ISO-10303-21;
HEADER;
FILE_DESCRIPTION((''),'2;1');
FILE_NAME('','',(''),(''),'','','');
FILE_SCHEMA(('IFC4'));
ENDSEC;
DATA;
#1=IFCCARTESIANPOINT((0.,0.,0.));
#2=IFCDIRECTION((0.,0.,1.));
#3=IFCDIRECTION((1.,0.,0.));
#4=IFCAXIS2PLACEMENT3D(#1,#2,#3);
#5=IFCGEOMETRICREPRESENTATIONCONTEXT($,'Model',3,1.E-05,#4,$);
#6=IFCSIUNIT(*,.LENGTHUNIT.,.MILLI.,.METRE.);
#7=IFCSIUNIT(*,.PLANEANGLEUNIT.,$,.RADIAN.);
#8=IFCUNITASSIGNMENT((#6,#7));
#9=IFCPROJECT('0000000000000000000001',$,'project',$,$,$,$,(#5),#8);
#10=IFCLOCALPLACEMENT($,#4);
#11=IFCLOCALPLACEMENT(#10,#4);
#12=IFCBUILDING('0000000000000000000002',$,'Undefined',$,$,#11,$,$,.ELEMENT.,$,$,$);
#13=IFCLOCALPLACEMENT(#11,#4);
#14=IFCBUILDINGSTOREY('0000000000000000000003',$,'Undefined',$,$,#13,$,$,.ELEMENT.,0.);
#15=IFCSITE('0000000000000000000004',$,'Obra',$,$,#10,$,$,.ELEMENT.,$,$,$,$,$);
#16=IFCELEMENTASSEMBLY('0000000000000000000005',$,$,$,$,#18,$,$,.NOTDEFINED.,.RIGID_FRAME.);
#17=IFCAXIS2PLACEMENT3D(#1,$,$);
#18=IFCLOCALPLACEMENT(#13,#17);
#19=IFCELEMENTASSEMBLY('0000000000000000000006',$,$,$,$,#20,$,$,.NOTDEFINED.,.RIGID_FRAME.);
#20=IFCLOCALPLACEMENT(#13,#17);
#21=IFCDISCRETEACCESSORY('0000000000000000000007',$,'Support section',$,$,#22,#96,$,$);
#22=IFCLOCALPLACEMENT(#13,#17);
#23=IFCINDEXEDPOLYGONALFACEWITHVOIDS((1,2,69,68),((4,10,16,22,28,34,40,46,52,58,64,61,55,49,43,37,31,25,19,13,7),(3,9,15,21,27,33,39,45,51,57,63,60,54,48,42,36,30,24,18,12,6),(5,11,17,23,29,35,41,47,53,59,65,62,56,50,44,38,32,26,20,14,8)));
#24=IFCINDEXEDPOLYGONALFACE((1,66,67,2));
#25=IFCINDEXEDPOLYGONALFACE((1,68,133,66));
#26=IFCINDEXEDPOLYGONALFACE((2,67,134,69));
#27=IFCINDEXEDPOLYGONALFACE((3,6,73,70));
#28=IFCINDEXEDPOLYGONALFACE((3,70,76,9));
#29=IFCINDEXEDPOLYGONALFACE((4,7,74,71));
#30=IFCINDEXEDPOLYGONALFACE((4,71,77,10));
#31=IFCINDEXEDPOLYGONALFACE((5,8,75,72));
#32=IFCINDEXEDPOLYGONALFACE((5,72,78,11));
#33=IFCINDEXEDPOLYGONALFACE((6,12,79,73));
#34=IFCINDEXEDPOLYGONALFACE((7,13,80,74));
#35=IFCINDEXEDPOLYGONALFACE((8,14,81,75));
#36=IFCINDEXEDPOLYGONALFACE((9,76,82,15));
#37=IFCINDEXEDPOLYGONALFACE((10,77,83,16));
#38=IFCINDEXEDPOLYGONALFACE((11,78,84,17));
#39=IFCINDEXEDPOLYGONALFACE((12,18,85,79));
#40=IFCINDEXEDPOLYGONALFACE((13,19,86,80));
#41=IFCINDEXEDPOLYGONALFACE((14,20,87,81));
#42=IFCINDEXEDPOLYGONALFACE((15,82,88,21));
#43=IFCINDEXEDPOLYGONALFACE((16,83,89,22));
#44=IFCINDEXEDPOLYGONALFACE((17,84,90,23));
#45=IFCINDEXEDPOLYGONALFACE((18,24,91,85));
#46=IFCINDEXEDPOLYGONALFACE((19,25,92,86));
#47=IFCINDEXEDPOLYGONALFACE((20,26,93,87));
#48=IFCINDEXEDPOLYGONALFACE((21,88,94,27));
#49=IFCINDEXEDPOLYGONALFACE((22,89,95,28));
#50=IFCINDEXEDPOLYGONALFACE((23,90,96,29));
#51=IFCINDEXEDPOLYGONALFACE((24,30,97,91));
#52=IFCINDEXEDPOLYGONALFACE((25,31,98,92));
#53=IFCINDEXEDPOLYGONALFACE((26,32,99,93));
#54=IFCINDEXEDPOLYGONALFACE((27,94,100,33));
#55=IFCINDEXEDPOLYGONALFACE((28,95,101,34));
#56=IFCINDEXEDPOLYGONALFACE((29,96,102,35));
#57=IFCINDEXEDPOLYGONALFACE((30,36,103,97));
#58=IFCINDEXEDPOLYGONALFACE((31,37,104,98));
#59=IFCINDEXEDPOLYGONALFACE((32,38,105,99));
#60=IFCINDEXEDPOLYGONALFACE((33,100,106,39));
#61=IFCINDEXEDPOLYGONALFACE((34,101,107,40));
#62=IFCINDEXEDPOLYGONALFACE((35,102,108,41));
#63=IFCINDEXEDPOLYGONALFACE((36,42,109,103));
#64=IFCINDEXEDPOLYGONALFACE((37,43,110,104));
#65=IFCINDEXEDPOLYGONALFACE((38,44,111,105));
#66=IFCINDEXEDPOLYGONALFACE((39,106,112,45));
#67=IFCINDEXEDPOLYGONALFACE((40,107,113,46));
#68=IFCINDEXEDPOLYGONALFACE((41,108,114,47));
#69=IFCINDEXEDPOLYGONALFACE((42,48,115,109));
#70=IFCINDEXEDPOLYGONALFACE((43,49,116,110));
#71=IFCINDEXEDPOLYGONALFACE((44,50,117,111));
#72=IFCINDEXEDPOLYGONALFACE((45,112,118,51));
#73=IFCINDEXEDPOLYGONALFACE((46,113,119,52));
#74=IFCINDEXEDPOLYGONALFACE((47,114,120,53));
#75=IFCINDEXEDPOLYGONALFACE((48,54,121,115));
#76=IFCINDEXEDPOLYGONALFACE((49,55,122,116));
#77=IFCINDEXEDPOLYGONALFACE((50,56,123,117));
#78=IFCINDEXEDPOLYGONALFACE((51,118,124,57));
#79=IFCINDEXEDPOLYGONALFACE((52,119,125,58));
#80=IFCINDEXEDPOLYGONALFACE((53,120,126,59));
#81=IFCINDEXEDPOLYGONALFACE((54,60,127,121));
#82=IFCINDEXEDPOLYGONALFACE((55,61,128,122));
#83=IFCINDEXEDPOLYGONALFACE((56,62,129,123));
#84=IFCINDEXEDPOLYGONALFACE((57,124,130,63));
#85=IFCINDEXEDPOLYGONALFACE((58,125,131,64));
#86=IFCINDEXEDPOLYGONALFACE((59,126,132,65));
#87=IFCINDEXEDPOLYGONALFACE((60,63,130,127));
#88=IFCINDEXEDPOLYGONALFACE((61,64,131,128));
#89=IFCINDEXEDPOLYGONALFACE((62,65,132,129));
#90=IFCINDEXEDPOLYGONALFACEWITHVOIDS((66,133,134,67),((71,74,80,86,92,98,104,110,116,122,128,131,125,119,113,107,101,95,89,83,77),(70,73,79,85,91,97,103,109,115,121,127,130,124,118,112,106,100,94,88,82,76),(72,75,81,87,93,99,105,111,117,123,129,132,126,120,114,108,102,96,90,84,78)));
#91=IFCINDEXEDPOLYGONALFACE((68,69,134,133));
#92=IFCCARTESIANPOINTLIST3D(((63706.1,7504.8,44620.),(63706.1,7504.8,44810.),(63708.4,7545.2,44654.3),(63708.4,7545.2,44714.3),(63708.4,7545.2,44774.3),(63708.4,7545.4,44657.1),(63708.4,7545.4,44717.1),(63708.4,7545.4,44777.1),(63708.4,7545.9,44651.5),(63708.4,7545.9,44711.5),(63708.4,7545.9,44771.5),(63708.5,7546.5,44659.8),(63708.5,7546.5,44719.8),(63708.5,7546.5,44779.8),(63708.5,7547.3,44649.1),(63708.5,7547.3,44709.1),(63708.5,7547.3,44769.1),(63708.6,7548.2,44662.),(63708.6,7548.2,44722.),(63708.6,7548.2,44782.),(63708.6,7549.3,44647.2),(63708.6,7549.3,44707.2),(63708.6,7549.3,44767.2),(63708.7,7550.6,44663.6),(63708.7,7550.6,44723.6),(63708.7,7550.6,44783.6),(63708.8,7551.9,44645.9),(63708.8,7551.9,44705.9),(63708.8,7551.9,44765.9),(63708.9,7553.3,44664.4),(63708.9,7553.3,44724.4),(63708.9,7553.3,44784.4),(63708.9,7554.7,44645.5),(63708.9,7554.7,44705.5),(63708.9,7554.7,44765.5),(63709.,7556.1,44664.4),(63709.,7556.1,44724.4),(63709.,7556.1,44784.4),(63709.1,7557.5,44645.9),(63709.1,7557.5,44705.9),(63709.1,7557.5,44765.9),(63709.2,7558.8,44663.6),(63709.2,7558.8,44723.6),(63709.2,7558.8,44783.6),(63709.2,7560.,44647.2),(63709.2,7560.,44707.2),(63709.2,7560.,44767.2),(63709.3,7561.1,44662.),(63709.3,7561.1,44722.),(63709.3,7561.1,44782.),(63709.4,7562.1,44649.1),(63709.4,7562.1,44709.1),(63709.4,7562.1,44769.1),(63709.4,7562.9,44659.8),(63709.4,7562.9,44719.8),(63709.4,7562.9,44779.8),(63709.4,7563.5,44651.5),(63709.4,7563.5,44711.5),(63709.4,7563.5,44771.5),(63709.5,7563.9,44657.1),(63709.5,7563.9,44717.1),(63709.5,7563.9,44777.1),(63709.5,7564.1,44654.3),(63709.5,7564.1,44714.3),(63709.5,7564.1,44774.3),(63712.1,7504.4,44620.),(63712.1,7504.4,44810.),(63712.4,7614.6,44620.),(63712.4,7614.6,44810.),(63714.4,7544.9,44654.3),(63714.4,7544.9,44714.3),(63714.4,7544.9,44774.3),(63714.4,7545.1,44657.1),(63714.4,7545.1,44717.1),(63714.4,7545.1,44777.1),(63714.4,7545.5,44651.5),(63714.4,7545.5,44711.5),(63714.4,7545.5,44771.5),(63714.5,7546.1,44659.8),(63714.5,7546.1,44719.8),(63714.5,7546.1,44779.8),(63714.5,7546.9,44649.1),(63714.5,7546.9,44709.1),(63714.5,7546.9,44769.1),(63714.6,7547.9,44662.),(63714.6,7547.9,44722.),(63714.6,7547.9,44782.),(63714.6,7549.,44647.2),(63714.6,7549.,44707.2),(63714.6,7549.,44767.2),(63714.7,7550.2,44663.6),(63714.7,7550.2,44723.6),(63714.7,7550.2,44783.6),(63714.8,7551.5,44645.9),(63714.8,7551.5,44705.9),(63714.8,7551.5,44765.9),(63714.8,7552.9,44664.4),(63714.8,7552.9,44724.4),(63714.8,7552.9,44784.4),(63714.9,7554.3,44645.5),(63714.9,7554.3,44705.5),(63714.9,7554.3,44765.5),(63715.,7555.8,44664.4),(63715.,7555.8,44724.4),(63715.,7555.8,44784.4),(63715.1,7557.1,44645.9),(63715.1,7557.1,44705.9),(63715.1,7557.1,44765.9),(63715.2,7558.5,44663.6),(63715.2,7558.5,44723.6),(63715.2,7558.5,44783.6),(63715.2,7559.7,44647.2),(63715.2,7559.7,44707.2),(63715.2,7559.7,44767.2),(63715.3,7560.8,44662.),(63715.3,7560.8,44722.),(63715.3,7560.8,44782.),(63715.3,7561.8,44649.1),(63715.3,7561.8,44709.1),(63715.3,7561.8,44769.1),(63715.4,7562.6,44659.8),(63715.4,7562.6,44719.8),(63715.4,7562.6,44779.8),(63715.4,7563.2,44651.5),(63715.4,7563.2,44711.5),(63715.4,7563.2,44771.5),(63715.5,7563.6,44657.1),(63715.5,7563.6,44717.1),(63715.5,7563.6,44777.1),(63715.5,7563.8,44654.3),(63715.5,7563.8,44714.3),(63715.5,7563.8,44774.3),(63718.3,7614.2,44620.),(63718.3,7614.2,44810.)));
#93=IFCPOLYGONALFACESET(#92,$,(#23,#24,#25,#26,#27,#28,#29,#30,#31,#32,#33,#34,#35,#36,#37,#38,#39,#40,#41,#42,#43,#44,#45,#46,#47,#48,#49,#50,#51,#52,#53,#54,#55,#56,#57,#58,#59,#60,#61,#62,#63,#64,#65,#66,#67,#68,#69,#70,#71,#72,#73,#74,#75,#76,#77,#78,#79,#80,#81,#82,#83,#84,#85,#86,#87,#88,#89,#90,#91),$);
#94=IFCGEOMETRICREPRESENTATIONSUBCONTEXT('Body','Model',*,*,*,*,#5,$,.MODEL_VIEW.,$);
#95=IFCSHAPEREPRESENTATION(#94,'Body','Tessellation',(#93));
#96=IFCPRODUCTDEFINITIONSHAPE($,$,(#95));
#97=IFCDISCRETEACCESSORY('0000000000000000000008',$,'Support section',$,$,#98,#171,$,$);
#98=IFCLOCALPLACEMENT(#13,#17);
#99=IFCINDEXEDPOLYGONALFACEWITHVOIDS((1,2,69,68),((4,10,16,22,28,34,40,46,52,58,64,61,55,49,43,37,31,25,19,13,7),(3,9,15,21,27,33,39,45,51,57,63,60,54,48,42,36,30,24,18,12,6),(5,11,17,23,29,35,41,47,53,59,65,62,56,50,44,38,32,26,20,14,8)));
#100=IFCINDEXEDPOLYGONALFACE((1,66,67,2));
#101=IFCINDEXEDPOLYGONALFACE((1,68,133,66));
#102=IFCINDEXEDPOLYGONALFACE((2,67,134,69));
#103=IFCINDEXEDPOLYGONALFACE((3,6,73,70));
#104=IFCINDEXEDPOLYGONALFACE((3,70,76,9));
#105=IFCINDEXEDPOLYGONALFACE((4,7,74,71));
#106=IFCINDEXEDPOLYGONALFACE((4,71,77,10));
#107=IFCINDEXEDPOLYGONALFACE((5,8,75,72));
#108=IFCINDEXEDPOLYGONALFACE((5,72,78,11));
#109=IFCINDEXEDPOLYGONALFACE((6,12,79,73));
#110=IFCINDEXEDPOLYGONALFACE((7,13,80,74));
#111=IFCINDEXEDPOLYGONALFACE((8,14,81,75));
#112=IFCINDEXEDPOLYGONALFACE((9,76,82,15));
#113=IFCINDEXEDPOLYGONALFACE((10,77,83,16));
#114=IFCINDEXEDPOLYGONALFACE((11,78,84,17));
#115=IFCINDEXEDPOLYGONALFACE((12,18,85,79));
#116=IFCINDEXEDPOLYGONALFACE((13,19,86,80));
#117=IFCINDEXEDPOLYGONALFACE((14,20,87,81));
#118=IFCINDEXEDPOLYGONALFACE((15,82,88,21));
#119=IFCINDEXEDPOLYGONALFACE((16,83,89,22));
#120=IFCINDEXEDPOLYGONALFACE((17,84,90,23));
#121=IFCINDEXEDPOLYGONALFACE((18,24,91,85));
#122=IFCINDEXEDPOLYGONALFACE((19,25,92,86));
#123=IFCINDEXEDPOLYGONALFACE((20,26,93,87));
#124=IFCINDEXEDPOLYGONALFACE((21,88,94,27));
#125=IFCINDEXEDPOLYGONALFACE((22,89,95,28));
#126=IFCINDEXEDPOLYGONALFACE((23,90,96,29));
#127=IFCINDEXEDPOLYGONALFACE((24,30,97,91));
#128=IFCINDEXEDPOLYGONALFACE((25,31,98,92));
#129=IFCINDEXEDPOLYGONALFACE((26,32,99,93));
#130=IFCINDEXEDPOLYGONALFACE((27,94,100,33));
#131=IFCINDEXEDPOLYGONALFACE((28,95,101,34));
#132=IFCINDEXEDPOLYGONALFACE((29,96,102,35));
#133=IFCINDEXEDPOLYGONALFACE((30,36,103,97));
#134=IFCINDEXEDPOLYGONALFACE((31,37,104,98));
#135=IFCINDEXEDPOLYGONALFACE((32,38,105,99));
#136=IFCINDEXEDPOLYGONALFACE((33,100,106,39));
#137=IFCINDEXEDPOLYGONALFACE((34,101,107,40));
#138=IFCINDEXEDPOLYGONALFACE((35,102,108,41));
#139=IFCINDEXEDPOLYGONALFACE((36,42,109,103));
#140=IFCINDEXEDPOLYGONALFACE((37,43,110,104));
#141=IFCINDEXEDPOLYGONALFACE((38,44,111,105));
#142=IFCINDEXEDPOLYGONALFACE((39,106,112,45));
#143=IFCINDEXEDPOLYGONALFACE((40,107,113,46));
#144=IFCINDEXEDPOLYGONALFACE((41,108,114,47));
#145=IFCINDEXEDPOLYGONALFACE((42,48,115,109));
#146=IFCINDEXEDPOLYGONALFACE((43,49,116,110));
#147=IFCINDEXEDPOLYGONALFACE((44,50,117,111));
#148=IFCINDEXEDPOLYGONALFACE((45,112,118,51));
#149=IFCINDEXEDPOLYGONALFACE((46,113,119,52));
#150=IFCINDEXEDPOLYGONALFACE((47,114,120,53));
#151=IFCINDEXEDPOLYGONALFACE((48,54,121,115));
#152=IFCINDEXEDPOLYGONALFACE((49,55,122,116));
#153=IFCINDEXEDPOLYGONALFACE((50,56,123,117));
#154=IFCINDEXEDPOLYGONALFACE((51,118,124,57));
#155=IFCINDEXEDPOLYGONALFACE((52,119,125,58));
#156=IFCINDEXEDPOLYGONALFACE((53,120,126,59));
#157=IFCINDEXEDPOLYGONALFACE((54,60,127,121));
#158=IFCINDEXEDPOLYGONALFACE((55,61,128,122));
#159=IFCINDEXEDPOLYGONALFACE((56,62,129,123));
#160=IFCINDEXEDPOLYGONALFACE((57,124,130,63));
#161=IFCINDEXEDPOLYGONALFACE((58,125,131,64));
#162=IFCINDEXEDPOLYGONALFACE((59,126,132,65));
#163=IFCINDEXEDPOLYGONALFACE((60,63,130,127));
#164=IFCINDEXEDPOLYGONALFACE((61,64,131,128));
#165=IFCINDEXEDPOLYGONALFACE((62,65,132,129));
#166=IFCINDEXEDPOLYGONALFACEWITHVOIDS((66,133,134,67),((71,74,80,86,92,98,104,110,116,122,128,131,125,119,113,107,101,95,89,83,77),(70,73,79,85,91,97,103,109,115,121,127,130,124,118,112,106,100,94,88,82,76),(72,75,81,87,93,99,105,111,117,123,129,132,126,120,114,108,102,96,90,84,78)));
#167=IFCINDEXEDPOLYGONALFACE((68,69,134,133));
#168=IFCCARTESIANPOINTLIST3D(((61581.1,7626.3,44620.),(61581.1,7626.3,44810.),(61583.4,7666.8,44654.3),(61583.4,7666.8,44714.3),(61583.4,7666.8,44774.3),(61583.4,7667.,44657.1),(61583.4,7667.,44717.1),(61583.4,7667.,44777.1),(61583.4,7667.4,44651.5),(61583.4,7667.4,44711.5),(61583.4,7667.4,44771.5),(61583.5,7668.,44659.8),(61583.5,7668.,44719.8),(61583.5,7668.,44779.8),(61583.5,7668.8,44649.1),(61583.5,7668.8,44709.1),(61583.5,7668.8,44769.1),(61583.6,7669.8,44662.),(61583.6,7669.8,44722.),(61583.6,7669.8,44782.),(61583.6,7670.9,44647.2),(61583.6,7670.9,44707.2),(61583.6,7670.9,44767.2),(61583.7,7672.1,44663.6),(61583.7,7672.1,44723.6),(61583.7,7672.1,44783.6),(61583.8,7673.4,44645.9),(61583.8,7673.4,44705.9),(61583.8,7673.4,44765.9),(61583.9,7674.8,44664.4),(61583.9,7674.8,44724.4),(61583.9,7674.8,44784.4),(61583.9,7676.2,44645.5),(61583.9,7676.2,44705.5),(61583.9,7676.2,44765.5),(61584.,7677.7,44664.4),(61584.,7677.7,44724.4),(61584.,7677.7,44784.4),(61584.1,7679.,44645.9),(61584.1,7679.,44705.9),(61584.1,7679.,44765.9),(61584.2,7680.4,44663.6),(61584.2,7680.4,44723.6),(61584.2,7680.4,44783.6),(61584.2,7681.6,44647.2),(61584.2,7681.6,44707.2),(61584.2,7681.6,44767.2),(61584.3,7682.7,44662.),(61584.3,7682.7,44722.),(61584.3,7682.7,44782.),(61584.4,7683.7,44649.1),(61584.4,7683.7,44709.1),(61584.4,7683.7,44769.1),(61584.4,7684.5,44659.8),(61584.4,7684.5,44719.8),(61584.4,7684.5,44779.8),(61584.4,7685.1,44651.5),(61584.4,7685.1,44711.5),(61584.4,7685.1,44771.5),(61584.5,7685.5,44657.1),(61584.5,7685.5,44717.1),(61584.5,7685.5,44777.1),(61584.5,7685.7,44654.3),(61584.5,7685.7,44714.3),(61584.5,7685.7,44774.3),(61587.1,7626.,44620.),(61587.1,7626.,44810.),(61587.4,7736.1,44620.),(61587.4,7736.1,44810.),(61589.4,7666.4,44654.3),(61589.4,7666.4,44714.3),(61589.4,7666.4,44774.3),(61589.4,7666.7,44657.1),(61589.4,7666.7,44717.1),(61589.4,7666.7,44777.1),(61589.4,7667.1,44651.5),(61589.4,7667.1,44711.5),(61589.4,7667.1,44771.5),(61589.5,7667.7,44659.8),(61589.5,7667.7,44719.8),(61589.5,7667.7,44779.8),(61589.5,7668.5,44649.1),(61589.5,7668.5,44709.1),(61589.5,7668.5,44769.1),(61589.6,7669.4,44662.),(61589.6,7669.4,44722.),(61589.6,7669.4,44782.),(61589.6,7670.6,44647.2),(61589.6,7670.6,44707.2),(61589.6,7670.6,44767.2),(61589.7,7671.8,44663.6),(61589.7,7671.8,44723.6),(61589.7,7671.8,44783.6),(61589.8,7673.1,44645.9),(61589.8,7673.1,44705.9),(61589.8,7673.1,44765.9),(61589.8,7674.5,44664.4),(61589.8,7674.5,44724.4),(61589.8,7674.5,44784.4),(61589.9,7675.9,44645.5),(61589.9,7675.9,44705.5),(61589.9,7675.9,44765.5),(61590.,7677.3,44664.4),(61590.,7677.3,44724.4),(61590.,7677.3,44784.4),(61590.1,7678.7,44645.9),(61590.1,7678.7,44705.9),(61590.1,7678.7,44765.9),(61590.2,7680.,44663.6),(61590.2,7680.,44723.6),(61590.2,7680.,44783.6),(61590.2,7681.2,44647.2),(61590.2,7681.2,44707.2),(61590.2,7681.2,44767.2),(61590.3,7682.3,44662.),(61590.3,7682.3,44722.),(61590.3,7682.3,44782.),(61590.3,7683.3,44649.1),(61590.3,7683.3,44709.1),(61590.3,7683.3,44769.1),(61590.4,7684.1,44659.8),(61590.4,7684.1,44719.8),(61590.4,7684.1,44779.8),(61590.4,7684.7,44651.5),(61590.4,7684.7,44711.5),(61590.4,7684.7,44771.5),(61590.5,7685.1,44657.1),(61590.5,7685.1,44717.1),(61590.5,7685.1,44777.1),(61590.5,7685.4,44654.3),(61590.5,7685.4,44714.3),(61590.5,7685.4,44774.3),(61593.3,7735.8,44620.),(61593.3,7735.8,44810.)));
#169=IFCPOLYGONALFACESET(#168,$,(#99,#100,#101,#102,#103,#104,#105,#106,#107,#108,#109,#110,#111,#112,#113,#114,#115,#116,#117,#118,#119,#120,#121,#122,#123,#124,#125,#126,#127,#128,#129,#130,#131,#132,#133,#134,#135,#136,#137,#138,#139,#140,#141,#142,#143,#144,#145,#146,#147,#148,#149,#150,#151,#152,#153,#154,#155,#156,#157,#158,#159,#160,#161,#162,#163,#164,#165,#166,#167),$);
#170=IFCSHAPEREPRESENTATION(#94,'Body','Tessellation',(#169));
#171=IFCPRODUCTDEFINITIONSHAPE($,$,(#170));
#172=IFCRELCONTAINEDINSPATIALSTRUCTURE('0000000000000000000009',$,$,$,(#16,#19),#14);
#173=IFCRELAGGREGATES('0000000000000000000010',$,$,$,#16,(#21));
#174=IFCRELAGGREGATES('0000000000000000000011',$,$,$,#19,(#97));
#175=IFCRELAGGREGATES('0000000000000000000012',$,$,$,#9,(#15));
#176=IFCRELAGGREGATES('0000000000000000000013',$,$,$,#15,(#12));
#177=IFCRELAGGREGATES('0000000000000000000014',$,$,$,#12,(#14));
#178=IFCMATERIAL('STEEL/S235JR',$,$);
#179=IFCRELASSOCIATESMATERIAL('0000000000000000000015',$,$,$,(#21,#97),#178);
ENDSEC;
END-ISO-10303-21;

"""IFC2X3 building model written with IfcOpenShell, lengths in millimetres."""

from ifc_helpers import new_model, si_unit, frame, origin_with_axes, origin_2d_with_axis, place, context, subcontext, project, spatial, rectangle, circle, extrude, source, transform, mapped, material, element, aggregate, save


model = new_model("IFC2X3")

# Units and contexts
model_context = context("Model", 3, precision=1e-05, world=origin_with_axes())
body_context = subcontext(model_context, "Body", "Model", "MODEL_VIEW")
ifc_project = project(units=[si_unit("LENGTHUNIT", "METRE", prefix="MILLI"), si_unit("PLANEANGLEUNIT", "RADIAN")], contexts=[model_context])

# Site, building, storey
site_placement = place(None, origin_with_axes())
site = spatial("IfcSite", under=ifc_project, at=site_placement, Name="Obra", CompositionType="ELEMENT")
building_placement = place(site_placement, origin_with_axes())
building = spatial("IfcBuilding", under=site, at=building_placement, Name="Undefined", CompositionType="ELEMENT")
storey_placement = place(building_placement, origin_with_axes())
storey = spatial("IfcBuildingStorey", under=building, at=storey_placement, Name="Undefined", CompositionType="ELEMENT", Elevation=0.0)

# Element assemblies
ifc_material_1 = material(Name="STEEL/S235JR")
assembly_1_placement = place(storey_placement, origin_with_axes())
assembly_1 = element("IfcElementAssembly", 1, at=assembly_1_placement, inside=storey, AssemblyPlace="NOTDEFINED", PredefinedType="RIGID_FRAME")
assembly_2_placement = place(storey_placement, origin_with_axes())
assembly_2 = element("IfcElementAssembly", 2, at=assembly_2_placement, inside=storey, AssemblyPlace="NOTDEFINED", PredefinedType="RIGID_FRAME")

# Discrete accessories, openings
discrete_accessory_1_placement = place(assembly_1_placement, frame((63712.2, 7559.5, 44620.0), z_axis=(0.0, 0.0, 1.0), x_axis=(0.05711, 0.998368, 0.0)))
discrete_accessory_1 = element("IfcDiscreteAccessory", 3, at=discrete_accessory_1_placement, material=ifc_material_1, Name="Support section", context=body_context, shape_type="SweptSolid", body=[
    extrude(rectangle(XDim=6.0, YDim=110.0, at=origin_2d_with_axis()), frame((0.0, 0.0, 190.0), z_axis=(0.0, 0.0, -1.0), x_axis=(0.0, 1.0, 0.0)), (0.0, 0.0, 1.0), 190.0),
])
shared_shape_1 = source(origin_with_axes(), body_context, "Body", "SweptSolid", [
    extrude(circle(Radius=9.5, at=origin_2d_with_axis()), frame((0.0, -9.2, 0.0), z_axis=(0.0, 1.0, 0.0), x_axis=(1.0, 0.0, 0.0)), (0.0, 0.0, 1.0), 6.2),
])
opening_1_placement = place(assembly_1_placement, frame((63720.9, 7604.1, 44835.0), z_axis=(-0.05711, -0.998368, 0.0), x_axis=(0.0, 0.0, -1.0)))
element("IfcOpeningElement", 4, at=opening_1_placement, cuts=discrete_accessory_1, ObjectType="Opening", context=body_context, shape_type="MappedRepresentation", body=[
    mapped(shared_shape_1, transform((60.0, 0.0, 50.0))),
    mapped(shared_shape_1, transform((120.0, 0.0, 50.0))),
    mapped(shared_shape_1, transform((180.0, 0.0, 50.0))),
])
aggregate(assembly_1, [discrete_accessory_1])
discrete_accessory_2_placement = place(assembly_2_placement, frame((61587.2, 7681.1, 44620.0), z_axis=(0.0, 0.0, 1.0), x_axis=(0.05711, 0.998368, 0.0)))
discrete_accessory_2 = element("IfcDiscreteAccessory", 5, at=discrete_accessory_2_placement, material=ifc_material_1, Name="Support section", context=body_context, shape_type="SweptSolid", body=[
    extrude(rectangle(XDim=6.0, YDim=110.0, at=origin_2d_with_axis()), frame((0.0, 0.0, 190.0), z_axis=(0.0, 0.0, -1.0), x_axis=(0.0, 1.0, 0.0)), (0.0, 0.0, 1.0), 190.0),
])
opening_2_placement = place(assembly_2_placement, frame((61595.9, 7725.6, 44835.0), z_axis=(-0.05711, -0.998368, 0.0), x_axis=(0.0, 0.0, -1.0)))
element("IfcOpeningElement", 6, at=opening_2_placement, cuts=discrete_accessory_2, ObjectType="Opening", context=body_context, shape_type="MappedRepresentation", body=[
    mapped(shared_shape_1, transform((60.0, 0.0, 50.0))),
    mapped(shared_shape_1, transform((120.0, 0.0, 50.0))),
    mapped(shared_shape_1, transform((180.0, 0.0, 50.0))),
])
aggregate(assembly_2, [discrete_accessory_2])

save(model, "model.ifc")
